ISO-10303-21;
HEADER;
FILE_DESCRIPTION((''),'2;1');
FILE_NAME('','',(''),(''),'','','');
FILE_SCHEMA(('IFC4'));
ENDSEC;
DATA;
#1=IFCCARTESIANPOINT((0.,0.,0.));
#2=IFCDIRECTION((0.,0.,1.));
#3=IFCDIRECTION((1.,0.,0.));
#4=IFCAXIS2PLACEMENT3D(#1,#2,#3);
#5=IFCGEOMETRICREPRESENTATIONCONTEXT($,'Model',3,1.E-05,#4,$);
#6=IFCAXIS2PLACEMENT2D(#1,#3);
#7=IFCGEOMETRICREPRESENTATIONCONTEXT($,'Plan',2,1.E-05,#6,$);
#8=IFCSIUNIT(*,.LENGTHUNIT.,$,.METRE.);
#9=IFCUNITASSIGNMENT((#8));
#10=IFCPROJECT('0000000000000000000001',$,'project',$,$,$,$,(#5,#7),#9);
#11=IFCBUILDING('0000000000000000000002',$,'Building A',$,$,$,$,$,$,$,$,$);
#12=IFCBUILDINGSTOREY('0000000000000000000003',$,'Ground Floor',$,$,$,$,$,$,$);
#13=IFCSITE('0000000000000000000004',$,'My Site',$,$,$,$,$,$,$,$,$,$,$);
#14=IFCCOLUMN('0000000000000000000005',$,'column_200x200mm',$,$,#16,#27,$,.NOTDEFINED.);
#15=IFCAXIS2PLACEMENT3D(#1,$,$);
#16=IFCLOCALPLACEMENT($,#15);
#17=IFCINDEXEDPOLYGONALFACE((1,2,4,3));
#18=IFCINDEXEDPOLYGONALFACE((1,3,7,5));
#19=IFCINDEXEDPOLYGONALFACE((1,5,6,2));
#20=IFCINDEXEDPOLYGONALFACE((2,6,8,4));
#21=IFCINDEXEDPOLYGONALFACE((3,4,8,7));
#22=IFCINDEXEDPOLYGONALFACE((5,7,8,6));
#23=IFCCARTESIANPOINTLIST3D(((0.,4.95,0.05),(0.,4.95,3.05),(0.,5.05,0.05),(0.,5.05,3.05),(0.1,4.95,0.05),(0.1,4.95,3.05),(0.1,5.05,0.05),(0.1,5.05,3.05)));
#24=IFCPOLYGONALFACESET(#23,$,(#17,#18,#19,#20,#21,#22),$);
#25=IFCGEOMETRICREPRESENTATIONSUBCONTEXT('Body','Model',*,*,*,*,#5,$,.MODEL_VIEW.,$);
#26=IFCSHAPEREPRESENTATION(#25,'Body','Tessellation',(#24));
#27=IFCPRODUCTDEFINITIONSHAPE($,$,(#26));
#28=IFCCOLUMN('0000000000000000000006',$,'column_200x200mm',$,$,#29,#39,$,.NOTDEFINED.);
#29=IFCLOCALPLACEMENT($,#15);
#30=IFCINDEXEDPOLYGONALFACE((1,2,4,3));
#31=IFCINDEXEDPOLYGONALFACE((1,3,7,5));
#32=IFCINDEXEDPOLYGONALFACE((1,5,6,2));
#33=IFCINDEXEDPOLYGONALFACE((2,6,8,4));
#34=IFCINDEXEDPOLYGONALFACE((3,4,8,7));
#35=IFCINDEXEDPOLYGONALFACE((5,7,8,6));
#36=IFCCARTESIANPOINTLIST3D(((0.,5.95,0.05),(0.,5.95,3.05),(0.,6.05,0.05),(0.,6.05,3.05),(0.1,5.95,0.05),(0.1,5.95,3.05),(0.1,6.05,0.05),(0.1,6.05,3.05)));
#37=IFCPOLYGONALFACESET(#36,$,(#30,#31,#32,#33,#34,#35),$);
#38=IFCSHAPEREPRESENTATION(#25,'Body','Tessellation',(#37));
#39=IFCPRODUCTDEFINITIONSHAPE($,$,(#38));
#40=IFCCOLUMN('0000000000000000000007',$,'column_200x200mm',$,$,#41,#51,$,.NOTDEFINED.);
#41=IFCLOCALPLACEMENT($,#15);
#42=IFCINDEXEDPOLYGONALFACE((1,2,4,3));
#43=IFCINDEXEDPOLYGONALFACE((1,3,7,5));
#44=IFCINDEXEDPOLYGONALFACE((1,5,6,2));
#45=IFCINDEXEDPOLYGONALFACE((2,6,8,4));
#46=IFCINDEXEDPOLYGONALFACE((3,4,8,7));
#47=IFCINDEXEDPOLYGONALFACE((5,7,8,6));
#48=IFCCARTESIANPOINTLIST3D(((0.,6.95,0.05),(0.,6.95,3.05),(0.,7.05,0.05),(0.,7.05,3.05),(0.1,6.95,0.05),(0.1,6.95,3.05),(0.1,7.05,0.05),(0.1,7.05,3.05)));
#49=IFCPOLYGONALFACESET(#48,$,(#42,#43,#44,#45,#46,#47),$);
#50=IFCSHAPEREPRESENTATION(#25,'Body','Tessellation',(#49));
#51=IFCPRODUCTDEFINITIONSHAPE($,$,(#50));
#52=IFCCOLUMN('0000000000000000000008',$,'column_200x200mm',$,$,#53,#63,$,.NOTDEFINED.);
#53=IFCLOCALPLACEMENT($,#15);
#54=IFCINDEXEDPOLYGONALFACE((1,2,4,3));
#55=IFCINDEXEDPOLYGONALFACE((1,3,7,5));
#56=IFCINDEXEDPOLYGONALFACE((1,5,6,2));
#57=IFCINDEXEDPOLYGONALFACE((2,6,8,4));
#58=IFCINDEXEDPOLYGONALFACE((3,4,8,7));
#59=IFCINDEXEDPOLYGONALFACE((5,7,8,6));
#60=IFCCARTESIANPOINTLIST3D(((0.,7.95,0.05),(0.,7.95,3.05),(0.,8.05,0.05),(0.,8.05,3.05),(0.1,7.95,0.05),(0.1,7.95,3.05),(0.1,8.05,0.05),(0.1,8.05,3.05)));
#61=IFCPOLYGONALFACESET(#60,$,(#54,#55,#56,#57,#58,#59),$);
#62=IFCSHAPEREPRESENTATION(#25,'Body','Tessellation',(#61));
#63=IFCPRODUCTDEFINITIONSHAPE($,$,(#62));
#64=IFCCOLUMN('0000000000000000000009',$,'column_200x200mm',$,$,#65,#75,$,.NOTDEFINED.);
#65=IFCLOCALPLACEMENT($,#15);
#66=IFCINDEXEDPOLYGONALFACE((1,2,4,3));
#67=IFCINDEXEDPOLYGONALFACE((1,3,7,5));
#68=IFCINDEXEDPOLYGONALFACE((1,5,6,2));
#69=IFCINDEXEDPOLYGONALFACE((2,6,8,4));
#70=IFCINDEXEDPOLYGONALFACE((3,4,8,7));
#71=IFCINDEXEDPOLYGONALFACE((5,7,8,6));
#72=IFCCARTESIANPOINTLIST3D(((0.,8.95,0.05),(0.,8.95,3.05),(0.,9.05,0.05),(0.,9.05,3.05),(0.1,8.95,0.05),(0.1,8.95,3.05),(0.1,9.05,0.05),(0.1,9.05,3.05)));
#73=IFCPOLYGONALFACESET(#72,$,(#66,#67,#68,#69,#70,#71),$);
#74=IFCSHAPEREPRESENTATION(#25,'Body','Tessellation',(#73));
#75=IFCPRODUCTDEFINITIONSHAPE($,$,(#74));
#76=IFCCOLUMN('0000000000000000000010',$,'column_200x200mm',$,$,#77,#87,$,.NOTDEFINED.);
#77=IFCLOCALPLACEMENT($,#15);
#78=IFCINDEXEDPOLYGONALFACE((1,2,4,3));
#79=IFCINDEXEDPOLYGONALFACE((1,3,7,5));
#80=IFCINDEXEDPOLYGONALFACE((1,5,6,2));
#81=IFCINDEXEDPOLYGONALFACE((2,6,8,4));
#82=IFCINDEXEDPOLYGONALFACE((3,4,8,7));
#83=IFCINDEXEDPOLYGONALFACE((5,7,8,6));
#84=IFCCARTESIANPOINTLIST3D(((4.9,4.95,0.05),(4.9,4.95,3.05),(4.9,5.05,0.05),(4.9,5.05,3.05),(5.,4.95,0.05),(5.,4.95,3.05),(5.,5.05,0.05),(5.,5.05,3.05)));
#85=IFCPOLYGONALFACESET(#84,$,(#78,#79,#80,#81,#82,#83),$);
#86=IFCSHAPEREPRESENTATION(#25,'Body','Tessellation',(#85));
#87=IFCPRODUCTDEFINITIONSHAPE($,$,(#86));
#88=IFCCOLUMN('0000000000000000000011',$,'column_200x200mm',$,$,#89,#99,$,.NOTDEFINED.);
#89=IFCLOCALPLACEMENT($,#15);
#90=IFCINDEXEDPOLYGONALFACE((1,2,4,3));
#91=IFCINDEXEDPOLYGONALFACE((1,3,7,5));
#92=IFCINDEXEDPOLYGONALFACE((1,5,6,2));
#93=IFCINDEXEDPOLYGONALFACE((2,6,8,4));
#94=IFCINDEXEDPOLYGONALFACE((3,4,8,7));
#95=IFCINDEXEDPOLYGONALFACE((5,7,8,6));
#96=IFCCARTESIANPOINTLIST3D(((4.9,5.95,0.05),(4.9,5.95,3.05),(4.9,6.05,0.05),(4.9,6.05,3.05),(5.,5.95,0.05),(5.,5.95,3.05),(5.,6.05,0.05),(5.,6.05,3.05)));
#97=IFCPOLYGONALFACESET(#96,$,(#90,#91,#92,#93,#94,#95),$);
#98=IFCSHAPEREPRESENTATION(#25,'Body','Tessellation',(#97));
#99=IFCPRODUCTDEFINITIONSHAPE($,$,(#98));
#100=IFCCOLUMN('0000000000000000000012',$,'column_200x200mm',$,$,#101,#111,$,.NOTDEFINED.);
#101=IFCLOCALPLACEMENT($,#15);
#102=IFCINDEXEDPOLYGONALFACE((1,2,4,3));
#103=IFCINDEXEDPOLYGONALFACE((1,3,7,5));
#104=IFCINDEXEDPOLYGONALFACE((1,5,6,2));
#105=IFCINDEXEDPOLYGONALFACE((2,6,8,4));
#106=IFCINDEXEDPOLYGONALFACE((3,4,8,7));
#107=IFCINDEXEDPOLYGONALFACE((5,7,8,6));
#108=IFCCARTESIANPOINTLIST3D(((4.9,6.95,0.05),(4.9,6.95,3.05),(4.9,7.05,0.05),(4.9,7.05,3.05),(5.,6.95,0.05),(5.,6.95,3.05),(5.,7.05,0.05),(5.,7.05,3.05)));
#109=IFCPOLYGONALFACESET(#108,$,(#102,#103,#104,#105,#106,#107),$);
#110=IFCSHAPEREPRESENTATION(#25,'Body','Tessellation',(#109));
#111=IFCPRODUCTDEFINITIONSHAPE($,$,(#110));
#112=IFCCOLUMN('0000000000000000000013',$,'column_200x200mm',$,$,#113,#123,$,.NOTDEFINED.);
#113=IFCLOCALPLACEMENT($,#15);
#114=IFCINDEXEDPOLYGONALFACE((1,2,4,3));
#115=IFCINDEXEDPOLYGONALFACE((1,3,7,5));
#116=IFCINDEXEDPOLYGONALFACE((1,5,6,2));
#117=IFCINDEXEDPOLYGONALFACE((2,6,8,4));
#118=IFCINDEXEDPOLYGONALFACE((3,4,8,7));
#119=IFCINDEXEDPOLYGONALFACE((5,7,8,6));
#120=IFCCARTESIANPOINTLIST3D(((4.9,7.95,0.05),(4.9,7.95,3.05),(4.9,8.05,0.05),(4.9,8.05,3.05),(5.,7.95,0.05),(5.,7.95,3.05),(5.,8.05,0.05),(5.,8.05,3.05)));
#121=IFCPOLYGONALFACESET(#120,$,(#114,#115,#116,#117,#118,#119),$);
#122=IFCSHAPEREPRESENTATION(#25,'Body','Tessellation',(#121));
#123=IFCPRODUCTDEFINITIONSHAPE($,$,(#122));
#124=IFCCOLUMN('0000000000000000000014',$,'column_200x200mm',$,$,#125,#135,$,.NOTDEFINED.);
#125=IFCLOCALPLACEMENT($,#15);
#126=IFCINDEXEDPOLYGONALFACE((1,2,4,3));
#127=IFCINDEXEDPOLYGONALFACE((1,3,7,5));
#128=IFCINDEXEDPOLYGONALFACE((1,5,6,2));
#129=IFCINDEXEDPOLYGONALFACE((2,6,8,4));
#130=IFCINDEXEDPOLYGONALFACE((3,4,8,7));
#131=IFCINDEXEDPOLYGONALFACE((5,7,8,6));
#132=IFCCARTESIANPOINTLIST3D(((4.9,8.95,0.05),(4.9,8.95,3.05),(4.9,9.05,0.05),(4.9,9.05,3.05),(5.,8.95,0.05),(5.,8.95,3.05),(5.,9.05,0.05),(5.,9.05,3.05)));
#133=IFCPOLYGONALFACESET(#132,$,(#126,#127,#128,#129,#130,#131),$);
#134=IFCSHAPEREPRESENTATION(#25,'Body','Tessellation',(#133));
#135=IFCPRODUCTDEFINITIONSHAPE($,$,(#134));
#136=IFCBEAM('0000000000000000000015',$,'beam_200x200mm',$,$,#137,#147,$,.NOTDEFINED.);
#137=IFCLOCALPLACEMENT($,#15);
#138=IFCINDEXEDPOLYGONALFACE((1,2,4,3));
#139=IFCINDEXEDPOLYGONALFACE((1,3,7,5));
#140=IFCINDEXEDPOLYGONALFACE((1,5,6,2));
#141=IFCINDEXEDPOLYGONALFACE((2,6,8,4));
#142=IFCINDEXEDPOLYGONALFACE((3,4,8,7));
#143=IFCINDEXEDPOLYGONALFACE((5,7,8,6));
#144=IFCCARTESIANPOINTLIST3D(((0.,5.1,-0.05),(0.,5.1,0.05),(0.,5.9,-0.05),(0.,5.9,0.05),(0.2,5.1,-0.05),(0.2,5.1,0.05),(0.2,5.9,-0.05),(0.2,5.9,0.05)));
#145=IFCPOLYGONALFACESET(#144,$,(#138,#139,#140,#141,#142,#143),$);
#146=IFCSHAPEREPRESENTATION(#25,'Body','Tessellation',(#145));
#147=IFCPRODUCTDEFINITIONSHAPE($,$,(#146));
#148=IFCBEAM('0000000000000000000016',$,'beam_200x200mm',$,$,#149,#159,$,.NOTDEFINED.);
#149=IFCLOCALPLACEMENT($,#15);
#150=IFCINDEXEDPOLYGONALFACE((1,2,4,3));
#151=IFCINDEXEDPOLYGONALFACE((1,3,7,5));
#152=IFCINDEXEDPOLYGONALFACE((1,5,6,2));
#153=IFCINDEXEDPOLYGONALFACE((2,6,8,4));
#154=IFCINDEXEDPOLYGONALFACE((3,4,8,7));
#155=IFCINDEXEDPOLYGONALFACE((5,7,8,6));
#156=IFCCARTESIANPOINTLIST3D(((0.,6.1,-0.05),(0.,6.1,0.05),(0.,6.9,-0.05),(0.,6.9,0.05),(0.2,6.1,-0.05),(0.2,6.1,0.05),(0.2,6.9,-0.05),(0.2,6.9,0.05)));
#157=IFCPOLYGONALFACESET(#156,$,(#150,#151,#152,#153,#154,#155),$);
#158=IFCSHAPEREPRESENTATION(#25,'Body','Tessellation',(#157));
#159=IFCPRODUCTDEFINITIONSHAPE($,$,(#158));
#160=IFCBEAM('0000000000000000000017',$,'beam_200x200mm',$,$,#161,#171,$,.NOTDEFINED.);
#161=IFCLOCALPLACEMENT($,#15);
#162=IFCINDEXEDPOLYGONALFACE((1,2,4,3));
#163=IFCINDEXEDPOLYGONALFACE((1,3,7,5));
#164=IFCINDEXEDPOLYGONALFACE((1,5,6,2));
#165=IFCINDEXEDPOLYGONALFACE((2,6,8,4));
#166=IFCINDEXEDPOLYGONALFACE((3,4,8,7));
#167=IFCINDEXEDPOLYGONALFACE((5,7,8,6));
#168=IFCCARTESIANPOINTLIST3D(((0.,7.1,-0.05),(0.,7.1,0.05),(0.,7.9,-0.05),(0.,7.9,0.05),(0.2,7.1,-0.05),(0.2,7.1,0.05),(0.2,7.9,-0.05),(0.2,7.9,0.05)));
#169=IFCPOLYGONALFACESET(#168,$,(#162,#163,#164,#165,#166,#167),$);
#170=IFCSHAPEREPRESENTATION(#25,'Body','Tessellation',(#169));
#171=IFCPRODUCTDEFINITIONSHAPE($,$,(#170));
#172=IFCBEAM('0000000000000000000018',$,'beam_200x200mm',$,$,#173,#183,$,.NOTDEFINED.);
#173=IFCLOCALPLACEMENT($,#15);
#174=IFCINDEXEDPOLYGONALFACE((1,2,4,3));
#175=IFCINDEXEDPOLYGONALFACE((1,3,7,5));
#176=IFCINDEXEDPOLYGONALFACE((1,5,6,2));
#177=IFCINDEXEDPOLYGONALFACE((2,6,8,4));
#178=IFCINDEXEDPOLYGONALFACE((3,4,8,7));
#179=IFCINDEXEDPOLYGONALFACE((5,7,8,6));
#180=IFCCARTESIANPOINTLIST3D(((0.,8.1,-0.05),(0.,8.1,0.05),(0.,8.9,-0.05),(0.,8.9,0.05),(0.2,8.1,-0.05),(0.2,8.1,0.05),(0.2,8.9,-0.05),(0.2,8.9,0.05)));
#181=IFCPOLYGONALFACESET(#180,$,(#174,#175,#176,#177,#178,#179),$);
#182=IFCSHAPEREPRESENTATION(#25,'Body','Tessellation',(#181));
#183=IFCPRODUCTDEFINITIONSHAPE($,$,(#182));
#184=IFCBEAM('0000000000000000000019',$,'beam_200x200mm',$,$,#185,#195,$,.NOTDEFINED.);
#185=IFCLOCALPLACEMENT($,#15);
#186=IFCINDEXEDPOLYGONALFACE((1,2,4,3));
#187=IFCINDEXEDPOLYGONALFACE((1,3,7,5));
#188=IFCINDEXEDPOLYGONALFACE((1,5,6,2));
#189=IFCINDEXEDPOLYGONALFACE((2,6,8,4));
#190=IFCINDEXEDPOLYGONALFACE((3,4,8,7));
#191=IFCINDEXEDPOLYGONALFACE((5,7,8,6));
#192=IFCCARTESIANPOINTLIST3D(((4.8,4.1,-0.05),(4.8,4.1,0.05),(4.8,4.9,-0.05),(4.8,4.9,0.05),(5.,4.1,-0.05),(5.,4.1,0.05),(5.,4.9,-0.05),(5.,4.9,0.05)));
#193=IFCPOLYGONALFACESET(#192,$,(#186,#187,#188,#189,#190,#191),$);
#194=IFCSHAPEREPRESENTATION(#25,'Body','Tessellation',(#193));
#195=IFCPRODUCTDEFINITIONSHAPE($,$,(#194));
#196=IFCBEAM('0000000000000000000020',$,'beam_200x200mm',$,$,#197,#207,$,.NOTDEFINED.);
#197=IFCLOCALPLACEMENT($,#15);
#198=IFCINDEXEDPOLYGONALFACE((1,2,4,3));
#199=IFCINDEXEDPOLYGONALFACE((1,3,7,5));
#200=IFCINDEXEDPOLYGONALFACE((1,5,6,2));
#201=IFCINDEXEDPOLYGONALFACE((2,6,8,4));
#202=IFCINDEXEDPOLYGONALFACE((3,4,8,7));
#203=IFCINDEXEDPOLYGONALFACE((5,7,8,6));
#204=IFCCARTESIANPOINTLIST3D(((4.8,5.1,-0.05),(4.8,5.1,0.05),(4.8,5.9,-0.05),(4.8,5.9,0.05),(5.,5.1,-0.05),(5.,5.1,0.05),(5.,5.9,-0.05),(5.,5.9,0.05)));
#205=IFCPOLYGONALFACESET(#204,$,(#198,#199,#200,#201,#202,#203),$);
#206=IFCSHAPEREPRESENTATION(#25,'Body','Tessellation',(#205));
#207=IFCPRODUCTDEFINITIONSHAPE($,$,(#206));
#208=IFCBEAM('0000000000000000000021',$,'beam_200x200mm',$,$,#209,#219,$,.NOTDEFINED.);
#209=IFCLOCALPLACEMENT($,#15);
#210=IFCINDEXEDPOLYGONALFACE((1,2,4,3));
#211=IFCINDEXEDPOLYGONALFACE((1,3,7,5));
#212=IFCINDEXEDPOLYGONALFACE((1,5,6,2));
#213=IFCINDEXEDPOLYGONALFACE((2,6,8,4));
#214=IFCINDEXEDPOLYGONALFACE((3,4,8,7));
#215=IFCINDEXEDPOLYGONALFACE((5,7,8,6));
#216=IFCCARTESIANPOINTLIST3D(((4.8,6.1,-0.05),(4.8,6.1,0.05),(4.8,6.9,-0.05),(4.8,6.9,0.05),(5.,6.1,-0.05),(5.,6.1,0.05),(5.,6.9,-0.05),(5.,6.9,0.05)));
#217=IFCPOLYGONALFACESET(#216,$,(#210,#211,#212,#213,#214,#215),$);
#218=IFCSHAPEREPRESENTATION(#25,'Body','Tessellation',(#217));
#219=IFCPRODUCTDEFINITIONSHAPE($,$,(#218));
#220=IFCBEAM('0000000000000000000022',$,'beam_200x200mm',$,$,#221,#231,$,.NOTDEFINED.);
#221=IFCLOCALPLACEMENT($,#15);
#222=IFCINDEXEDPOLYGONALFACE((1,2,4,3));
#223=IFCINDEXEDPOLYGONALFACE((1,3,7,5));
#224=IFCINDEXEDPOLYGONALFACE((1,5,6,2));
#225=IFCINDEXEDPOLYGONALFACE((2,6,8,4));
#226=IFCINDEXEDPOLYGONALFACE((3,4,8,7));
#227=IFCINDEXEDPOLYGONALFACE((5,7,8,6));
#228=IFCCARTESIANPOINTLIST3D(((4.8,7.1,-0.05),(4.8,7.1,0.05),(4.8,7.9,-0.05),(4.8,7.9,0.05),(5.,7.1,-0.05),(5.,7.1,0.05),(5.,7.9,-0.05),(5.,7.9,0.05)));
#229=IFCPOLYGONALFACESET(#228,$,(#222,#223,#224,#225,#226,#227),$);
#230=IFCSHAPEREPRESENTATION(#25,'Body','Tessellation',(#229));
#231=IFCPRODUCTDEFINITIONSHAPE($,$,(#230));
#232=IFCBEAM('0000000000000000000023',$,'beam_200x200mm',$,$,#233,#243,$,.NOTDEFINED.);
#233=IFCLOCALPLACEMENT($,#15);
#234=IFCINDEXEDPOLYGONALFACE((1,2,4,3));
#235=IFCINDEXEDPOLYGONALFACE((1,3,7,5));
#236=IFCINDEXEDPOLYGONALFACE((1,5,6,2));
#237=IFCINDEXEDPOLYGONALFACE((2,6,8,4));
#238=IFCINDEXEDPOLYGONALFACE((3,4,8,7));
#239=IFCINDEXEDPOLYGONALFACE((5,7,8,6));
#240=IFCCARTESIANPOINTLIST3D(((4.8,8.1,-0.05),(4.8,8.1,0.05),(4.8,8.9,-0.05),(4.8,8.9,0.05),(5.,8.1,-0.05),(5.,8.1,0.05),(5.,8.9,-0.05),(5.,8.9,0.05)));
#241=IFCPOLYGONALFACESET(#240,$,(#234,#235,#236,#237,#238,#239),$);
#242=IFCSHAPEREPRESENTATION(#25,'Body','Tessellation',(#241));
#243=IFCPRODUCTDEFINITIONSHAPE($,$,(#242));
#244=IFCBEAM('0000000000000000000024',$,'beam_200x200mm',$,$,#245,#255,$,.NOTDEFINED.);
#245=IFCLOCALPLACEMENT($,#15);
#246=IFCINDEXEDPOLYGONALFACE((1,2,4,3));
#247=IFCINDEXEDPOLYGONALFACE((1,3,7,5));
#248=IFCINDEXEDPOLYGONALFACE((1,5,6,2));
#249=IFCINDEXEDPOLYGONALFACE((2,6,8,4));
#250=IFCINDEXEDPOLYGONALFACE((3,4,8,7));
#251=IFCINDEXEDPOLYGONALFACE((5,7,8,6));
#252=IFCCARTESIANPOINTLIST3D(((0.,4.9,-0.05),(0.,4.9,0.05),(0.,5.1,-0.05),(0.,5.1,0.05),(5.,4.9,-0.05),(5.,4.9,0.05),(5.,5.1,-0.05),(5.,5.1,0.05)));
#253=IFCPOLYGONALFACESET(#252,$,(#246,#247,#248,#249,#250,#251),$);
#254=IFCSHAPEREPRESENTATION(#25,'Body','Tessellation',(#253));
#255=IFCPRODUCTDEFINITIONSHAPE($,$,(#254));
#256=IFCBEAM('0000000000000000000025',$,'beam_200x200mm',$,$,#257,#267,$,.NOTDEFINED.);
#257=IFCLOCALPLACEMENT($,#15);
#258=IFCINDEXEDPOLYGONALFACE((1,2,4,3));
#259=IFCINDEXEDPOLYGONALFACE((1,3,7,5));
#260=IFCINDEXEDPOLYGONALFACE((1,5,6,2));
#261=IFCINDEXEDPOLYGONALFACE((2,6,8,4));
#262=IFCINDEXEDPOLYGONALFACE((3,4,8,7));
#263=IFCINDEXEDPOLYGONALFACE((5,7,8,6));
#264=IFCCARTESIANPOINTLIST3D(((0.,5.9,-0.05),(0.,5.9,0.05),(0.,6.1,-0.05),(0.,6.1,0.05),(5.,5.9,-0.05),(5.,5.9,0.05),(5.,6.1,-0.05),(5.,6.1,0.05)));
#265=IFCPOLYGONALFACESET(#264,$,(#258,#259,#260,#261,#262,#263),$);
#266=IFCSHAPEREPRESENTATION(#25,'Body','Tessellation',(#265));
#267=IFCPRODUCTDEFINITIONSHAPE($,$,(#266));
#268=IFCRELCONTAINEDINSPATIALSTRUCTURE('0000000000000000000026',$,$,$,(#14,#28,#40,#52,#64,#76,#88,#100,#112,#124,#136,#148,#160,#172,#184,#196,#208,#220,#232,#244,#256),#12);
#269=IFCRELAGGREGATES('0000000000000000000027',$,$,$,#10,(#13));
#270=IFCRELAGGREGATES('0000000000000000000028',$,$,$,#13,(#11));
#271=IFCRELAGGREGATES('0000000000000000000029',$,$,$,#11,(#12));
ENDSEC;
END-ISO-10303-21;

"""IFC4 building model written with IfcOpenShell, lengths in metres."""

from ifc_helpers import new_model, si_unit, frame, frame_2d, origin_with_axes, place, context, subcontext, project, spatial, rectangle, extrude, element, save


model = new_model("IFC4")

# Units and contexts
model_context = context("Model", 3, precision=1e-05, world=origin_with_axes())
plan_context = context("Plan", 2, precision=1e-05, world=frame_2d((0.0, 0.0, 0.0), x_axis=(1.0, 0.0, 0.0)))
body_context = subcontext(model_context, "Body", "Model", "MODEL_VIEW")
ifc_project = project(units=[si_unit("LENGTHUNIT", "METRE")], contexts=[model_context, plan_context])

# Site, building, storey
site = spatial("IfcSite", under=ifc_project, Name="My Site")
building = spatial("IfcBuilding", under=site, Name="Building A")
storey = spatial("IfcBuildingStorey", under=building, Name="Ground Floor")

# Columns
for number, where, z_axis, x_axis, name in (
    (1, (0.05, 5.0, 0.05), (0.0, 0.0, 1.0), (1.0, 0.0, 0.0), "column_200x200mm"),
    (2, (0.05, 6.0, 0.05), (0.0, 0.0, 1.0), (1.0, 0.0, 0.0), "column_200x200mm"),
    (3, (0.05, 7.0, 0.05), (0.0, 0.0, 1.0), (1.0, 0.0, 0.0), "column_200x200mm"),
    (4, (0.05, 8.0, 0.05), (0.0, 0.0, 1.0), (1.0, 0.0, 0.0), "column_200x200mm"),
    (5, (0.05, 9.0, 0.05), (0.0, 0.0, 1.0), (1.0, 0.0, 0.0), "column_200x200mm"),
    (6, (4.95, 5.0, 0.05), (0.0, 0.0, 1.0), (1.0, 0.0, 0.0), "column_200x200mm"),
    (7, (4.95, 6.0, 0.05), (0.0, 0.0, 1.0), (1.0, 0.0, 0.0), "column_200x200mm"),
    (8, (4.95, 7.0, 0.05), (0.0, 0.0, 1.0), (1.0, 0.0, 0.0), "column_200x200mm"),
    (9, (4.95, 8.0, 0.05), (0.0, 0.0, 1.0), (1.0, 0.0, 0.0), "column_200x200mm"),
    (10, (4.95, 9.0, 0.05), (0.0, 0.0, 1.0), (1.0, 0.0, 0.0), "column_200x200mm"),
):
    element("IfcColumn", number, at=place(None, frame(where, z_axis=z_axis, x_axis=x_axis)), inside=storey, Name=name, PredefinedType="NOTDEFINED", context=body_context, shape_type="SweptSolid", body=[
        extrude(rectangle(XDim=0.1, YDim=0.1), origin_with_axes(), (0.0, 0.0, 1.0), 3.0),
    ])

# Beams
for number, where, z_axis, x_axis, name in (
    (11, (0.1, 5.1, 0.0), (0.0, 1.0, 0.0), (0.0, 1.0, 1.0), "beam_200x200mm"),
    (12, (0.1, 6.1, 0.0), (0.0, 1.0, 0.0), (0.0, 1.0, 1.0), "beam_200x200mm"),
    (13, (0.1, 7.1, 0.0), (0.0, 1.0, 0.0), (0.0, 1.0, 1.0), "beam_200x200mm"),
    (14, (0.1, 8.1, 0.0), (0.0, 1.0, 0.0), (0.0, 1.0, 1.0), "beam_200x200mm"),
    (15, (4.9, 4.1, 0.0), (0.0, 1.0, 0.0), (0.0, 1.0, 1.0), "beam_200x200mm"),
    (16, (4.9, 5.1, 0.0), (0.0, 1.0, 0.0), (0.0, 1.0, 1.0), "beam_200x200mm"),
    (17, (4.9, 6.1, 0.0), (0.0, 1.0, 0.0), (0.0, 1.0, 1.0), "beam_200x200mm"),
    (18, (4.9, 7.1, 0.0), (0.0, 1.0, 0.0), (0.0, 1.0, 1.0), "beam_200x200mm"),
    (19, (4.9, 8.1, 0.0), (0.0, 1.0, 0.0), (0.0, 1.0, 1.0), "beam_200x200mm"),
):
    element("IfcBeam", number, at=place(None, frame(where, z_axis=z_axis, x_axis=x_axis)), inside=storey, Name=name, PredefinedType="NOTDEFINED", context=body_context, shape_type="SweptSolid", body=[
        extrude(rectangle(XDim=0.1, YDim=0.2), origin_with_axes(), (0.0, 0.0, 1.0), 0.8),
    ])
for number, where, z_axis, x_axis, name in (
    (20, (0.0, 5.0, 0.0), (1.0, 0.0, 0.0), (0.0, 0.0, 1.0), "beam_200x200mm"),
    (21, (0.0, 6.0, 0.0), (1.0, 0.0, 0.0), (0.0, 0.0, 1.0), "beam_200x200mm"),
):
    element("IfcBeam", number, at=place(None, frame(where, z_axis=z_axis, x_axis=x_axis)), inside=storey, Name=name, PredefinedType="NOTDEFINED", context=body_context, shape_type="SweptSolid", body=[
        extrude(rectangle(XDim=0.1, YDim=0.2), origin_with_axes(), (0.0, 0.0, 1.0), 5.0),
    ])

save(model, "model.ifc")
